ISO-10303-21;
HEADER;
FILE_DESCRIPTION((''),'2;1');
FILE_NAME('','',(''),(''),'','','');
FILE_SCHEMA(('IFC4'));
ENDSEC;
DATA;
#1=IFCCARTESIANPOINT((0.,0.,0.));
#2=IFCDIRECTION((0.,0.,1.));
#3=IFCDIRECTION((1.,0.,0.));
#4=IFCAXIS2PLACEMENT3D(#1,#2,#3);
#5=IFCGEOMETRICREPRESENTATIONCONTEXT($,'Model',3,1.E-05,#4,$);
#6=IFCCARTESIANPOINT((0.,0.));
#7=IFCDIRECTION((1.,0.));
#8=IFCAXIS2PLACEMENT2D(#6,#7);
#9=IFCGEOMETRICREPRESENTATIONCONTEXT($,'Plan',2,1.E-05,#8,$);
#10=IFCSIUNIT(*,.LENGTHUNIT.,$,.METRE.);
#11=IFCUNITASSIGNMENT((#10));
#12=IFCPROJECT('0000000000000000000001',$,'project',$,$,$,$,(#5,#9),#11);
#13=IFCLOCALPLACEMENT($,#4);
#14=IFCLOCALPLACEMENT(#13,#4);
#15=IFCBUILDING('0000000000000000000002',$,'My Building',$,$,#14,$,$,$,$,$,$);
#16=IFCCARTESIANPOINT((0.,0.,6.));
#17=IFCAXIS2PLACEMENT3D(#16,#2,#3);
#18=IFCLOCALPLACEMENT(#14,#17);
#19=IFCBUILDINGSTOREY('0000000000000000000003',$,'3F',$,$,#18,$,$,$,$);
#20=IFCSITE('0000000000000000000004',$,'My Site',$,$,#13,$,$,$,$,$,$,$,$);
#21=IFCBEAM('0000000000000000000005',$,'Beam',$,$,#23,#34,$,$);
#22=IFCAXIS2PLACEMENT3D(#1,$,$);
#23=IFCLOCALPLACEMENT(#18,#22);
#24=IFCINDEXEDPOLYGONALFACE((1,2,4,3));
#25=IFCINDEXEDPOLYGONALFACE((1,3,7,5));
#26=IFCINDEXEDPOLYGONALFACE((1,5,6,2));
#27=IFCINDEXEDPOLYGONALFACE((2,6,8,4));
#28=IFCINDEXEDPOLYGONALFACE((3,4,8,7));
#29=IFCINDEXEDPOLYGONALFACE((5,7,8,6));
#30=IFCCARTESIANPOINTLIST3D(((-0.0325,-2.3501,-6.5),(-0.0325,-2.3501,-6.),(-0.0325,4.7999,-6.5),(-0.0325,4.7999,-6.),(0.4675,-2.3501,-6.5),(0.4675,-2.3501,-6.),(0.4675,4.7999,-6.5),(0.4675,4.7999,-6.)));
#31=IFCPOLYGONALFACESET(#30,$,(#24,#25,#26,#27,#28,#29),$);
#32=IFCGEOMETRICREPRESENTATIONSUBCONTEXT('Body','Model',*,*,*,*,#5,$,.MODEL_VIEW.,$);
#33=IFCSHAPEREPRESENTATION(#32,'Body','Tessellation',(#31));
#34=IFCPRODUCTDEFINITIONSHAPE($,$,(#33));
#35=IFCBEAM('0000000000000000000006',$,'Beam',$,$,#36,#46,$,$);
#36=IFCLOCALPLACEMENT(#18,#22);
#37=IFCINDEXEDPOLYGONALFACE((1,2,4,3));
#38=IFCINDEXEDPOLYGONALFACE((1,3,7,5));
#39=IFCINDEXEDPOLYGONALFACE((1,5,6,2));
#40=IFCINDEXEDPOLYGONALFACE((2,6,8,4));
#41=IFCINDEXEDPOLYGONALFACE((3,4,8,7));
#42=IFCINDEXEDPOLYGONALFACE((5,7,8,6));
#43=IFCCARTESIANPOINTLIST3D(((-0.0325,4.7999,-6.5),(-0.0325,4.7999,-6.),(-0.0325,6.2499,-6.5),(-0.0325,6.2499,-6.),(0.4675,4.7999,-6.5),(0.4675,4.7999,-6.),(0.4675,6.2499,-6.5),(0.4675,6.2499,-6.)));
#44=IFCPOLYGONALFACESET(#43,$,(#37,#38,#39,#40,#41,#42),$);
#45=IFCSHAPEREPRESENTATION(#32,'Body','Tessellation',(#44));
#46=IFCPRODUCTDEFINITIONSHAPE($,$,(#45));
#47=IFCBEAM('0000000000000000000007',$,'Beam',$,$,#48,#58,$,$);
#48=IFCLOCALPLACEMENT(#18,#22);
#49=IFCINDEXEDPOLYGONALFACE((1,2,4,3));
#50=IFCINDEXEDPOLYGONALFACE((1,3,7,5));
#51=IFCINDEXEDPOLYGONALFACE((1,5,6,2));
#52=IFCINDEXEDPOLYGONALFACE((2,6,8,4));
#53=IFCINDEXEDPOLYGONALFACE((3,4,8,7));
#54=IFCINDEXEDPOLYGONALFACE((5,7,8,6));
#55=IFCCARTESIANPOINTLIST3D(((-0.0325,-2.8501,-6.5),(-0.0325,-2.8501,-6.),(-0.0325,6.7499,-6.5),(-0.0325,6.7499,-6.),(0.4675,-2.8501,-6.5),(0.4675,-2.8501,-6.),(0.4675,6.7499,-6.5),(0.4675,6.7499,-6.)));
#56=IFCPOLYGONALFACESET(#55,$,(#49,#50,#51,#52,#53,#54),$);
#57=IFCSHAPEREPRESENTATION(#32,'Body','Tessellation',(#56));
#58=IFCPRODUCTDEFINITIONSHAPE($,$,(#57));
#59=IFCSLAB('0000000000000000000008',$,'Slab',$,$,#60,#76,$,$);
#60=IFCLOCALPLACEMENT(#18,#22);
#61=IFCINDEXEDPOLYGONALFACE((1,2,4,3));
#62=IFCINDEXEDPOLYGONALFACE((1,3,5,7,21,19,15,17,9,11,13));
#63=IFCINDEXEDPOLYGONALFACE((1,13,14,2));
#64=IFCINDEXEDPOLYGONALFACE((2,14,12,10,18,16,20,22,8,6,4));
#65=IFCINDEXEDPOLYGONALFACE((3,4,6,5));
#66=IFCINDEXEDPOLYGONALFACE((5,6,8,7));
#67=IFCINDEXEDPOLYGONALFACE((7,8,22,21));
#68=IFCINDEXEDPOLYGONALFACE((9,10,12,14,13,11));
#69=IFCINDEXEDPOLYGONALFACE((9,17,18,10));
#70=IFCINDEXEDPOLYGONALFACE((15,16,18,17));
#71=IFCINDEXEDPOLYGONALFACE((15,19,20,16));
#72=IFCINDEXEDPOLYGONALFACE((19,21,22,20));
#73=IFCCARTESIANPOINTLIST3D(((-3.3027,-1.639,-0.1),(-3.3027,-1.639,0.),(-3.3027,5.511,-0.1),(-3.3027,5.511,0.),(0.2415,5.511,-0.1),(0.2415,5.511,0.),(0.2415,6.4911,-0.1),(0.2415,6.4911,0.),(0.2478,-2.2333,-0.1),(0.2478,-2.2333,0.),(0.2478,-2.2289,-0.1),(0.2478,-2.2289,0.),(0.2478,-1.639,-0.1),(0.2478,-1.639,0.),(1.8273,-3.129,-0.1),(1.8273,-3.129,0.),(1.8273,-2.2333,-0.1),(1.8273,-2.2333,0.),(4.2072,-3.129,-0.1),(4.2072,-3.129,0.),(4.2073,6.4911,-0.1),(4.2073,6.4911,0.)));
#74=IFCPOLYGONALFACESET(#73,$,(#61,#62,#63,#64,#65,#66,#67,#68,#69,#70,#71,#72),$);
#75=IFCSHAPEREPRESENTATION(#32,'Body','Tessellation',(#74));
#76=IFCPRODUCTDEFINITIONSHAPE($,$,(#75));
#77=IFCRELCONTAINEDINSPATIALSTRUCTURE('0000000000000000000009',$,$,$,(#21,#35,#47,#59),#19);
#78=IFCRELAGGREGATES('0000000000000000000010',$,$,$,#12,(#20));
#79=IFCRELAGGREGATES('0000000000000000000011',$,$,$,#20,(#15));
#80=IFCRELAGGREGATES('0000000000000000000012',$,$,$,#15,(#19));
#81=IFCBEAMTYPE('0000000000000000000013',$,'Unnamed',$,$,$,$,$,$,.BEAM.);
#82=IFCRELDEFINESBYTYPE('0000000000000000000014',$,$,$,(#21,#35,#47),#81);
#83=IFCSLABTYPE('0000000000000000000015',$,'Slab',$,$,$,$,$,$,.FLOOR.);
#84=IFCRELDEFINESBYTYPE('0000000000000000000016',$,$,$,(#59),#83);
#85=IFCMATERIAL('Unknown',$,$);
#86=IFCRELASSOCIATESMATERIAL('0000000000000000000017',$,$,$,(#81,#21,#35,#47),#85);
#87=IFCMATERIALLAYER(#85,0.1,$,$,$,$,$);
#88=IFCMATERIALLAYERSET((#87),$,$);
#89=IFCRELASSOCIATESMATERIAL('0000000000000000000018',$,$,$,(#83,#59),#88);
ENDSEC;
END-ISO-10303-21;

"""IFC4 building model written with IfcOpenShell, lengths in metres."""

from ifc_helpers import new_model, si_unit, frame, origin_with_axes, origin_2d_with_axis, place, context, subcontext, project, spatial, indexed_curve, rectangle, outline, extrude, material, layer, layer_set, layer_usage, material_profile, profile_set, profile_usage, type_object, element, save


model = new_model("IFC4")

# Units and contexts
model_context = context("Model", 3, precision=1e-05, world=origin_with_axes())
plan_context = context("Plan", 2, precision=1e-05, world=origin_2d_with_axis())
body_context = subcontext(model_context, "Body", "Model", "MODEL_VIEW")
ifc_project = project(units=[si_unit("LENGTHUNIT", "METRE")], contexts=[model_context, plan_context])

# Site, building, storey
site_placement = place(None, origin_with_axes())
site = spatial("IfcSite", under=ifc_project, at=site_placement, Name="My Site")
building_placement = place(site_placement, origin_with_axes())
building = spatial("IfcBuilding", under=site, at=building_placement, Name="My Building")
storey_placement = place(building_placement, frame((0.0, 0.0, 6.0), z_axis=(0.0, 0.0, 1.0), x_axis=(1.0, 0.0, 0.0)))
storey = spatial("IfcBuildingStorey", under=building, at=storey_placement, Name="3F")

# Beams
ifc_material = material(Name="Unknown")
ifc_material_profile = material_profile(ifc_material, rectangle(XDim=0.5, YDim=0.5))
ifc_profile_set = profile_set([ifc_material_profile])
ifc_profile_usage_1 = profile_usage(ifc_profile_set, cardinal=7)
beam_type = type_object("IfcBeamType", Name="Unnamed", PredefinedType="BEAM", material=ifc_profile_set)
beam_1_placement = place(storey_placement, frame((-0.0325, -2.3501, -6.0), z_axis=(0.0, 1.0, 0.0), x_axis=(-1.0, 0.0, 0.0)))
element("IfcBeam", 1, at=beam_1_placement, inside=storey, type_object=beam_type, material=ifc_profile_usage_1, Name="Beam", context=body_context, shape_type="SweptSolid", body=[
    extrude(rectangle(XDim=0.5, YDim=0.5), frame((-0.25, -0.25, 0.0), z_axis=(0.0, 0.0, 1.0), x_axis=(1.0, 0.0, 0.0)), (0.0, 0.0, 1.0), 7.15),
])
ifc_profile_usage_2 = profile_usage(ifc_profile_set, cardinal=7)
beam_2_placement = place(storey_placement, frame((-0.0325, 4.7999, -6.0), z_axis=(0.0, 1.0, 0.0), x_axis=(-1.0, 0.0, 0.0)))
element("IfcBeam", 2, at=beam_2_placement, inside=storey, type_object=beam_type, material=ifc_profile_usage_2, Name="Beam", context=body_context, shape_type="SweptSolid", body=[
    extrude(rectangle(XDim=0.5, YDim=0.5), frame((-0.25, -0.25, 0.0), z_axis=(0.0, 0.0, 1.0), x_axis=(1.0, 0.0, 0.0)), (0.0, 0.0, 1.0), 1.45),
])
ifc_profile_usage_3 = profile_usage(ifc_profile_set, cardinal=7)
beam_3_placement = place(storey_placement, frame((0.4675, 6.7499, -6.0), z_axis=(0.0, -1.0, 0.0), x_axis=(1.0, 0.0, 0.0)))
element("IfcBeam", 3, at=beam_3_placement, inside=storey, type_object=beam_type, material=ifc_profile_usage_3, Name="Beam", context=body_context, shape_type="SweptSolid", body=[
    extrude(rectangle(XDim=0.5, YDim=0.5), frame((-0.25, -0.25, 0.0), z_axis=(0.0, 0.0, 1.0), x_axis=(1.0, 0.0, 0.0)), (0.0, 0.0, 1.0), 9.6),
])

# Slab
ifc_layer = layer(ifc_material, 0.1)
ifc_layer_set = layer_set([ifc_layer])
ifc_layer_usage = layer_usage(ifc_layer_set, "AXIS3", "POSITIVE", -0.1)
slab_type = type_object("IfcSlabType", Name="Slab", PredefinedType="FLOOR", material=ifc_layer_set)
slab_placement = place(storey_placement, frame((4.2073, 6.4911, 0.0), z_axis=(0.0, 0.0, 1.0), x_axis=(1.0, 0.0, 0.0)))
element("IfcSlab", 4, at=slab_placement, inside=storey, type_object=slab_type, material=ifc_layer_usage, Name="Slab", context=body_context, shape_type="SweptSolid", body=[
    extrude(outline(indexed_curve([(0.0, 0.0), (-3.9658, 0.0), (-3.9658, -0.9801), (-7.51, -0.9801), (-7.51, -8.13), (-3.9595, -8.13), (-3.9595, -8.72), (-3.9595, -8.7244), (-2.38, -8.7244), (-2.38, -9.62), (-0.0001, -9.62), (0.0, 0.0)])), frame((0.0, 0.0, -0.1), z_axis=(0.0, 0.0, 1.0), x_axis=(1.0, 0.0, 0.0)), (0.0, 0.0, 1.0), 0.1),
])

save(model, "model.ifc")
